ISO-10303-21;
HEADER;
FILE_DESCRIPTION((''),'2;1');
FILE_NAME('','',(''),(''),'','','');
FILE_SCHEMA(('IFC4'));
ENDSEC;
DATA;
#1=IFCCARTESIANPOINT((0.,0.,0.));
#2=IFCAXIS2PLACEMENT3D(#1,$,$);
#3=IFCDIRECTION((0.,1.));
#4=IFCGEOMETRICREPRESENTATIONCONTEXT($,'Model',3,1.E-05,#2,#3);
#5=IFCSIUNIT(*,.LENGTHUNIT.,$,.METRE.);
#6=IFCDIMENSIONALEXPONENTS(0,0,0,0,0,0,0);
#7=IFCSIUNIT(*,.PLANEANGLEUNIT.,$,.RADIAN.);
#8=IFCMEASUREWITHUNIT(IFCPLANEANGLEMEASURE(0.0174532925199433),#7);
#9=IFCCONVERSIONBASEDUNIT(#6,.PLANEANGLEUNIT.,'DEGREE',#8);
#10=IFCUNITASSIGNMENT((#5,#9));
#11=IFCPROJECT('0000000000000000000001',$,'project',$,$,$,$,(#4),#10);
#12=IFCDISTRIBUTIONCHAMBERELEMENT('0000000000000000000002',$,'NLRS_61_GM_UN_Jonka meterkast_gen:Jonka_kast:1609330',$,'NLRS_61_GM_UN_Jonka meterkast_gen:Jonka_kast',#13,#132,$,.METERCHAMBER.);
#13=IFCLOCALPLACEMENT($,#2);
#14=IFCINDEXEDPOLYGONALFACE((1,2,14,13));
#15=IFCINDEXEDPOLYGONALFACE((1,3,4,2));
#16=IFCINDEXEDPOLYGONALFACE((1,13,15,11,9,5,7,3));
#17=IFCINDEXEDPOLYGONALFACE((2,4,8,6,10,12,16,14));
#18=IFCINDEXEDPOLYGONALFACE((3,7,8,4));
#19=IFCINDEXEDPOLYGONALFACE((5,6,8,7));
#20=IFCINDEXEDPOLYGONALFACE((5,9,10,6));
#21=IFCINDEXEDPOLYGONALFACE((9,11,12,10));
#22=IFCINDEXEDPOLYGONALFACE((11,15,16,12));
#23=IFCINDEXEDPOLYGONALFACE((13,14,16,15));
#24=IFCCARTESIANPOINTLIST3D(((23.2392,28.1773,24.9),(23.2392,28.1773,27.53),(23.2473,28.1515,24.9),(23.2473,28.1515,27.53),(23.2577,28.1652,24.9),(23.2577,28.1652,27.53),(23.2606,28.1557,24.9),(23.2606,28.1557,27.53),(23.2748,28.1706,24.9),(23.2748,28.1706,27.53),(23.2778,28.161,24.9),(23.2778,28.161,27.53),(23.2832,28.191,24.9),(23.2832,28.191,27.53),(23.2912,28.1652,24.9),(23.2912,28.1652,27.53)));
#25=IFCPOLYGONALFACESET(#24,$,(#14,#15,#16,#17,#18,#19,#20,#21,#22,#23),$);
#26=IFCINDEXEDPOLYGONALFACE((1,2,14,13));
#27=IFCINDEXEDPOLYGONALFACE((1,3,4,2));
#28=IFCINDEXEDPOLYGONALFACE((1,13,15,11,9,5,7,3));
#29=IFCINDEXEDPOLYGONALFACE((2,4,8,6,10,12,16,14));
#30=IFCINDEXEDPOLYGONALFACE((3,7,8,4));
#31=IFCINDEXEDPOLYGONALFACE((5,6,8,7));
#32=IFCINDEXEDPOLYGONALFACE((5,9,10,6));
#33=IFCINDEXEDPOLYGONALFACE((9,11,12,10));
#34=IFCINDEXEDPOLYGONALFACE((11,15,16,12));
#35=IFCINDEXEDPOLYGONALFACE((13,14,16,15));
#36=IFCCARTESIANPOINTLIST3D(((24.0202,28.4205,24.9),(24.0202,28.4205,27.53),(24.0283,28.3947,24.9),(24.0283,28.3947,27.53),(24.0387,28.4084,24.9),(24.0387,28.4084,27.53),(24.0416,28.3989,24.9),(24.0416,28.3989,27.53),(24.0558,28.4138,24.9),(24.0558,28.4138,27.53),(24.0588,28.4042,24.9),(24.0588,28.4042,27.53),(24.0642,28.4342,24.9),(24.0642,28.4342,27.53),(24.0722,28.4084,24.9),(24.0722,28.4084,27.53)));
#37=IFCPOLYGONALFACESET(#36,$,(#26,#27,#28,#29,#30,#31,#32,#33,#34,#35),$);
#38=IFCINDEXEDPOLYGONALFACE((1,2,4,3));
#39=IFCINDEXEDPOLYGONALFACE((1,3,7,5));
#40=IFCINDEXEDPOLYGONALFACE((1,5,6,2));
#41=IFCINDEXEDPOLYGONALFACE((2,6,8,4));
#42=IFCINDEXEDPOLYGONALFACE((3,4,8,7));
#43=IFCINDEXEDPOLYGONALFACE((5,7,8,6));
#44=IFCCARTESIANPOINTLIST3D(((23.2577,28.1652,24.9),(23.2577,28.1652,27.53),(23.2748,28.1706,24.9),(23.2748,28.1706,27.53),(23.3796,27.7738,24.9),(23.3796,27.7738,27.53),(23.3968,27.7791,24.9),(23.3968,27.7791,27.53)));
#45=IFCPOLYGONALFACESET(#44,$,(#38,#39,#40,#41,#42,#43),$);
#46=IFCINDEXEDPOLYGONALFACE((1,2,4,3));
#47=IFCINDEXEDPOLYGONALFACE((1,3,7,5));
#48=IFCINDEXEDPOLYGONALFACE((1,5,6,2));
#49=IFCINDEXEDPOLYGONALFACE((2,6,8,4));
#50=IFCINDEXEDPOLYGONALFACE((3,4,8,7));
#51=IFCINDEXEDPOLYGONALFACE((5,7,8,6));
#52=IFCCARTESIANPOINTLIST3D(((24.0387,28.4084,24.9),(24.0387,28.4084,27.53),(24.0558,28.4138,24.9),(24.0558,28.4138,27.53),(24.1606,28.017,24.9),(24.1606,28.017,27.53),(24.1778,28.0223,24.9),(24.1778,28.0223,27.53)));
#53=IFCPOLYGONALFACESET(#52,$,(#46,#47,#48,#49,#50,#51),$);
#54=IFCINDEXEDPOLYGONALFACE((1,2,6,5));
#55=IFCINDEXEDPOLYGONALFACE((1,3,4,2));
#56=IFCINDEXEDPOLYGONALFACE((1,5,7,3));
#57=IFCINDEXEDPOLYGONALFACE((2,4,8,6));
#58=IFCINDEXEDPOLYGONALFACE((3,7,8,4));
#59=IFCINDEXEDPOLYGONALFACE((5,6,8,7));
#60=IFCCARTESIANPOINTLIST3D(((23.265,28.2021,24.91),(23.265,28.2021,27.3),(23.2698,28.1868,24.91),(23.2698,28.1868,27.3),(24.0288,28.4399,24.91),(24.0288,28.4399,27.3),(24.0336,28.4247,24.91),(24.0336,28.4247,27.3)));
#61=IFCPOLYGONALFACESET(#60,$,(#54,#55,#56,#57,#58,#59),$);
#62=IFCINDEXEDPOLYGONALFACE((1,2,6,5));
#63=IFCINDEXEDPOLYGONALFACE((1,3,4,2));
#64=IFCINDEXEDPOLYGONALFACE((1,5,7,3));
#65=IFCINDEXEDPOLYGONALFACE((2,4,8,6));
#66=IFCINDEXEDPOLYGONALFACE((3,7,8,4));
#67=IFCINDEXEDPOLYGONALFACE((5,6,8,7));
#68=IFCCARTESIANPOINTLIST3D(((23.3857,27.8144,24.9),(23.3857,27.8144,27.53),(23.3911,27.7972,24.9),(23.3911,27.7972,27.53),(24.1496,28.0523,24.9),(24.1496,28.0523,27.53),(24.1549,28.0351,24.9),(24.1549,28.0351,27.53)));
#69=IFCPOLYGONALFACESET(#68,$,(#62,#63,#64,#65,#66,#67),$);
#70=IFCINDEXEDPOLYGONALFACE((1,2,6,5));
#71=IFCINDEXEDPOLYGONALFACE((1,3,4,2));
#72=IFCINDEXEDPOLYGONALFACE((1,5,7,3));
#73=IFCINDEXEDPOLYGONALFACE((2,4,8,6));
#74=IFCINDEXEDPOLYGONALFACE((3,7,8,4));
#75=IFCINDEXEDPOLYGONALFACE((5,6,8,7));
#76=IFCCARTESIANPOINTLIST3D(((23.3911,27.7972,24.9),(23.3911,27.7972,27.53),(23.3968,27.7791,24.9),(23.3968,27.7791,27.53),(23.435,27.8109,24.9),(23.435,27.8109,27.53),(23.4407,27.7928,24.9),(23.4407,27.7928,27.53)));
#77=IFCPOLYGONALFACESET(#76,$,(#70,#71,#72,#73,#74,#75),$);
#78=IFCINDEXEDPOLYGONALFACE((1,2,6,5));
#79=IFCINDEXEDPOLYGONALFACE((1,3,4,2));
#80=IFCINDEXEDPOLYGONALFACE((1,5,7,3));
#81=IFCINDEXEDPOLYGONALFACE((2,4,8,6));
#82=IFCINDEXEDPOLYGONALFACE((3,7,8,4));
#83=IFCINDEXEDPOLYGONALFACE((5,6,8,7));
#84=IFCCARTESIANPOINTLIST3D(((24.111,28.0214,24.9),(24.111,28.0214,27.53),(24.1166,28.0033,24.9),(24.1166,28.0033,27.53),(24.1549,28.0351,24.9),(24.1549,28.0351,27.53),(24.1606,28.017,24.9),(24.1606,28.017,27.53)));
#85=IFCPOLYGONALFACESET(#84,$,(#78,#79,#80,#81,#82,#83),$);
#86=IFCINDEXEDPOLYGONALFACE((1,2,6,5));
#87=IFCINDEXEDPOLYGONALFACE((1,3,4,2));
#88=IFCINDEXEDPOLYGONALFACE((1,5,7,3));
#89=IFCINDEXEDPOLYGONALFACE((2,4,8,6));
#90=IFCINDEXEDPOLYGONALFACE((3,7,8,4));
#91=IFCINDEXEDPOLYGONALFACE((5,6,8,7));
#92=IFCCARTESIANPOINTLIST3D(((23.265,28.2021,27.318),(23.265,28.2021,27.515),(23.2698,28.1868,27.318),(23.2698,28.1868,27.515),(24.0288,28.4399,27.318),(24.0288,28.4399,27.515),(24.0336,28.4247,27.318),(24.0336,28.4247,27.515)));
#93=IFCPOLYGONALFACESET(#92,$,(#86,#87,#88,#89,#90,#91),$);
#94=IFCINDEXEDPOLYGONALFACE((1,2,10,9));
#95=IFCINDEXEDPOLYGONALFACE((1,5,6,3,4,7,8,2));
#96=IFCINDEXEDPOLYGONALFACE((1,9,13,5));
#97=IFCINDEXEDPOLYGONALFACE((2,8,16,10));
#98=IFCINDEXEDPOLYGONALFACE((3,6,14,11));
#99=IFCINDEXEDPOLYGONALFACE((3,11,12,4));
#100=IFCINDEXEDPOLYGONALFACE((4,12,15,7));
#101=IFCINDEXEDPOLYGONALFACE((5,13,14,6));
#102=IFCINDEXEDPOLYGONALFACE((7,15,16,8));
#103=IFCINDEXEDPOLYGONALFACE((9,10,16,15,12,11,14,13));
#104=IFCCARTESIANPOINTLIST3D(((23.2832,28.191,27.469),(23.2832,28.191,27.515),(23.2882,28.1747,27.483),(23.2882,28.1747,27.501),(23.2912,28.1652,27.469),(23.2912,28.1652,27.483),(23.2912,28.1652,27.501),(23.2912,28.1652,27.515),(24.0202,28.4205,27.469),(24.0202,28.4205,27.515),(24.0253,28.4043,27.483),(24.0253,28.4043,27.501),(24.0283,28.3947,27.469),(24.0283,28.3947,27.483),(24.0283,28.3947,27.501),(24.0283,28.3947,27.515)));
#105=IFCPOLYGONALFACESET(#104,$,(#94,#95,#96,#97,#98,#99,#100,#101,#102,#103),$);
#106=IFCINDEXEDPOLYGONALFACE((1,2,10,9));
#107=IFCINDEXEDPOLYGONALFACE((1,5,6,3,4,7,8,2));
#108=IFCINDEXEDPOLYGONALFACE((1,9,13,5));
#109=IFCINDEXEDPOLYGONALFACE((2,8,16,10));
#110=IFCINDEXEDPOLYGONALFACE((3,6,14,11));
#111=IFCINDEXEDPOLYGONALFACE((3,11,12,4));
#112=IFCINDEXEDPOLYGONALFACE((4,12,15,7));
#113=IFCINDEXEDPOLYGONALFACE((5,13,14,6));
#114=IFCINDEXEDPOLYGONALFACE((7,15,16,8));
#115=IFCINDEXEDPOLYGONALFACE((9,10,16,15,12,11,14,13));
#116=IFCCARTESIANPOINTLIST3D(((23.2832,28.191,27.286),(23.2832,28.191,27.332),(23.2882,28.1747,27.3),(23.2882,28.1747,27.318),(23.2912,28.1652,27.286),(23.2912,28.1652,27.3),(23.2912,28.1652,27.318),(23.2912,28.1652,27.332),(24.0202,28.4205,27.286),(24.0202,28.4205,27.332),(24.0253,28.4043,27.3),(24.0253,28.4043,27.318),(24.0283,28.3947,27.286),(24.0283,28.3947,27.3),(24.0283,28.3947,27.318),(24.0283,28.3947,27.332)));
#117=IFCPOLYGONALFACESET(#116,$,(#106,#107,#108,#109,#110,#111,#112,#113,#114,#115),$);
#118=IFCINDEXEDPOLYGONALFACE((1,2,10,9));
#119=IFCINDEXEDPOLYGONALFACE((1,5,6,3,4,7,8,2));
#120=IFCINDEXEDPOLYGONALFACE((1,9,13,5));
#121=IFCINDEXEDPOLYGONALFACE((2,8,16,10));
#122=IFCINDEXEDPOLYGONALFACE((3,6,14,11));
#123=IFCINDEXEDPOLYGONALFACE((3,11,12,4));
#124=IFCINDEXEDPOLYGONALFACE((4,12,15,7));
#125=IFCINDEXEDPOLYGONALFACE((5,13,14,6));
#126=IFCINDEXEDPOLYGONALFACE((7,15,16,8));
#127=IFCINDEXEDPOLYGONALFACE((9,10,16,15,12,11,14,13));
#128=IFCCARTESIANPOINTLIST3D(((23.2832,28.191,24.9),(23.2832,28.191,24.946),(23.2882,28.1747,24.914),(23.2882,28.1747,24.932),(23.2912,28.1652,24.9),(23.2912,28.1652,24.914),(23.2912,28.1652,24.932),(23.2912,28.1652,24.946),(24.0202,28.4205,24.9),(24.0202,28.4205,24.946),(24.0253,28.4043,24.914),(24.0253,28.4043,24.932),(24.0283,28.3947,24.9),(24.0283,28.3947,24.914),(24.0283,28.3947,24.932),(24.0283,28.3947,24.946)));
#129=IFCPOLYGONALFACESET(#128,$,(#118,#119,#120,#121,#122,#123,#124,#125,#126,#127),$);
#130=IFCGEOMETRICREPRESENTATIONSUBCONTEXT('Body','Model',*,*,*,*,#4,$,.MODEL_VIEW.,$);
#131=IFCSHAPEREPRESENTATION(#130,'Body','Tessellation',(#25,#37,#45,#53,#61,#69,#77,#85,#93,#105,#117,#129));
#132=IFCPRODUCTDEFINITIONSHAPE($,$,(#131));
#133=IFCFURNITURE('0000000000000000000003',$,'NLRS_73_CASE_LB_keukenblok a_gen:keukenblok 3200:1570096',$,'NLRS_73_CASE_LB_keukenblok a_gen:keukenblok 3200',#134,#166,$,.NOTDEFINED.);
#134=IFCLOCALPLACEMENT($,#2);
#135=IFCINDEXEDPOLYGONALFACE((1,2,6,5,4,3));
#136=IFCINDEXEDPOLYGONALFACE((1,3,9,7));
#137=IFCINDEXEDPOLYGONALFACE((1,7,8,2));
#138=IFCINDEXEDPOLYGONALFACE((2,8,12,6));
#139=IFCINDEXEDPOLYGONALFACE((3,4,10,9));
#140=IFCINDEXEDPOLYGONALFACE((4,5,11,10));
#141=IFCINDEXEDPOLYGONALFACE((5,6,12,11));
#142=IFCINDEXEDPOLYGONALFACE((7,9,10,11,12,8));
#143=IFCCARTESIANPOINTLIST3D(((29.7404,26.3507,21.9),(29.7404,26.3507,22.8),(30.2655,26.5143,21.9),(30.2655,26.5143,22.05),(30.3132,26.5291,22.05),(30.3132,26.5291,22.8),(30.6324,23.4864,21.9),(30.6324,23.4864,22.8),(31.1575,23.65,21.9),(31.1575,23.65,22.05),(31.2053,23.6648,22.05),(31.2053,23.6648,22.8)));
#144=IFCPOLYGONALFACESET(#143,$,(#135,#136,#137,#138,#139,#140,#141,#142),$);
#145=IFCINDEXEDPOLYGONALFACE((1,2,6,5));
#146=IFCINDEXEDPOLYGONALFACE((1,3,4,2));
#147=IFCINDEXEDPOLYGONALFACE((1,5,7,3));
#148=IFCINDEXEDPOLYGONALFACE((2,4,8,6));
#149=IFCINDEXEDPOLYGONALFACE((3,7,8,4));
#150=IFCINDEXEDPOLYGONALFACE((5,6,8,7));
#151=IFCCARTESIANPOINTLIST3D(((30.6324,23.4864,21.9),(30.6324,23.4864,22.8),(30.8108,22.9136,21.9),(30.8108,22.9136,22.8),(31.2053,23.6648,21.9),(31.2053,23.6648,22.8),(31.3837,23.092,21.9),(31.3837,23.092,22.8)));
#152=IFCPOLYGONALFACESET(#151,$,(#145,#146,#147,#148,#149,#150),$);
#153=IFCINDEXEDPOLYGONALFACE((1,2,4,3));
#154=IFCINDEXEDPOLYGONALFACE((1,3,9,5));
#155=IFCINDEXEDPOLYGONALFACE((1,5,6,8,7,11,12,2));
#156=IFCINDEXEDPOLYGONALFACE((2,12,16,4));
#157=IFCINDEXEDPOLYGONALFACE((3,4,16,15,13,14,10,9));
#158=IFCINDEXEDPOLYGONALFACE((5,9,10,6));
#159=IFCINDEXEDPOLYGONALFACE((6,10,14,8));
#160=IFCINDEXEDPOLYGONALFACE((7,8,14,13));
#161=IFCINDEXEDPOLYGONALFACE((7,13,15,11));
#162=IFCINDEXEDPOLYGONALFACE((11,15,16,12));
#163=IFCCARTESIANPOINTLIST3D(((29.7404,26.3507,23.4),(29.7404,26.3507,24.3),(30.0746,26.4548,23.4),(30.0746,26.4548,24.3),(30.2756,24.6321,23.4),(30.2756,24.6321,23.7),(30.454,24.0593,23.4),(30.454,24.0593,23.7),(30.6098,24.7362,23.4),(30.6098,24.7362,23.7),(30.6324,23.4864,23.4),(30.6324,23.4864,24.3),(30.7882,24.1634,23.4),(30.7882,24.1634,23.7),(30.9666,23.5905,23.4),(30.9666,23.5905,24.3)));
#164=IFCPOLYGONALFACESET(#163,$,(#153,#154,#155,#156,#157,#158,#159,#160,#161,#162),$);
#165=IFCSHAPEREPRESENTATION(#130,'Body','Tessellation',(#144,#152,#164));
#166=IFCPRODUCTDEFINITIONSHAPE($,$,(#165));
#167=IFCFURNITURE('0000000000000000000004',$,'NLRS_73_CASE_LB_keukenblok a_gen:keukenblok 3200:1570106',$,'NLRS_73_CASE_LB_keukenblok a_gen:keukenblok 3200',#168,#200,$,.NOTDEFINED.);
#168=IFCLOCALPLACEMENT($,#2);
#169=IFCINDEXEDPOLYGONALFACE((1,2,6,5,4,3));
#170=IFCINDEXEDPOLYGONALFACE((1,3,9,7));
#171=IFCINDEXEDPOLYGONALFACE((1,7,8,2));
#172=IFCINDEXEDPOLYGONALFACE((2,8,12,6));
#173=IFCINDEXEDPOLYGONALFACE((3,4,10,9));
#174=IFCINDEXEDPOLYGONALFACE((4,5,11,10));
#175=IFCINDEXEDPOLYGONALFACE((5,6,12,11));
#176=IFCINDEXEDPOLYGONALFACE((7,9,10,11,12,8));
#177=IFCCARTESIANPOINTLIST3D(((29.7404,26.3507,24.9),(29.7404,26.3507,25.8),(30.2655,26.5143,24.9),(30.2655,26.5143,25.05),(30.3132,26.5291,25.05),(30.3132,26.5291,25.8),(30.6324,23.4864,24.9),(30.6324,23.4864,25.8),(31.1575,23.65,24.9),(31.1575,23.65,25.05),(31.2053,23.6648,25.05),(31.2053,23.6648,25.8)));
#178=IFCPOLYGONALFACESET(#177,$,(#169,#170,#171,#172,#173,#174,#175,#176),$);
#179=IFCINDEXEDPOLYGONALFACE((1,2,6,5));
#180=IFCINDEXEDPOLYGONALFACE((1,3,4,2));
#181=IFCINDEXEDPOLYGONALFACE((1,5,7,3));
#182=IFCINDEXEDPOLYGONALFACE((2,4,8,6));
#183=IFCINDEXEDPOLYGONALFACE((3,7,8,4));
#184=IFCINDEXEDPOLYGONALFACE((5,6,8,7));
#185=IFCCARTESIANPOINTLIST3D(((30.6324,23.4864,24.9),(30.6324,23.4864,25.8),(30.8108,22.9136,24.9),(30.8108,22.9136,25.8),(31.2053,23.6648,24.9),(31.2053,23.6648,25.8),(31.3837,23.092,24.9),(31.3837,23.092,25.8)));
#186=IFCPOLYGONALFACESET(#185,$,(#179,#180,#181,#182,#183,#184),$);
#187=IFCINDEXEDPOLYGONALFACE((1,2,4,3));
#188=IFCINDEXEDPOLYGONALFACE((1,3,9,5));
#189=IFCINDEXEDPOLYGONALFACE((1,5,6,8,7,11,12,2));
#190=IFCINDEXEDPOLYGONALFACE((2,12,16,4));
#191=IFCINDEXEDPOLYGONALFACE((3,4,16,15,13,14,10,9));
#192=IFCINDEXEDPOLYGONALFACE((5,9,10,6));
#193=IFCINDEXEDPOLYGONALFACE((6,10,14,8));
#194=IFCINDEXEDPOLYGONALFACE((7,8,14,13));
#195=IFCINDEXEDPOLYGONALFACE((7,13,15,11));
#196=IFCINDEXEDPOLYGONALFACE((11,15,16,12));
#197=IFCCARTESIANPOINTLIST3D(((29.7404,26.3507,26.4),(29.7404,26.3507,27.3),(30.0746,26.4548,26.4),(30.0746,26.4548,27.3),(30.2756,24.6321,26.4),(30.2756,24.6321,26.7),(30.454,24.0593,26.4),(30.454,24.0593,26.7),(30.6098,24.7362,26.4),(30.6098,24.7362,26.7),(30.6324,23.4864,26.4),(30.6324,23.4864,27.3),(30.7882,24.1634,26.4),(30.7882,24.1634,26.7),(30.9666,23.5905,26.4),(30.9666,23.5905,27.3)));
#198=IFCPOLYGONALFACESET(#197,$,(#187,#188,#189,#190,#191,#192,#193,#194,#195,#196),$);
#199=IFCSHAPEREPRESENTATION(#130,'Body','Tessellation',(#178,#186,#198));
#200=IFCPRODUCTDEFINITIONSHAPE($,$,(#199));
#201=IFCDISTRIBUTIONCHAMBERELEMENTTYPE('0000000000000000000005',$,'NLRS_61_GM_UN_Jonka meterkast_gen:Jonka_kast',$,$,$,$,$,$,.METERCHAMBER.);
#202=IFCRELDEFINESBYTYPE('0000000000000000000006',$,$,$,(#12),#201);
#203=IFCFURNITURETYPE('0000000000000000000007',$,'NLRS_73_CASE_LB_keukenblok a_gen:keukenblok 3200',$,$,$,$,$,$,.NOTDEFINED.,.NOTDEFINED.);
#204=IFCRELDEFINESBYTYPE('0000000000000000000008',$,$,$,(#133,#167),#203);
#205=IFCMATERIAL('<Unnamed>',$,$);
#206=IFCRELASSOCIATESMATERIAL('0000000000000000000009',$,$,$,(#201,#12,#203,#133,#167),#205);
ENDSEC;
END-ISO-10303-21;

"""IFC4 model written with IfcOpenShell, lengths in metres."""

from ifc_helpers import new_model, entity, si_unit, converted_unit, direction, frame, origin, place, context, subcontext, project, indexed_curve, outline, extrude, source, transform, mapped, material, type_object, type_shapes, element, save


model = new_model("IFC4")

# Units and contexts
model_context = context("Model", 3, precision=1e-05, world=origin(), true_north=direction((0.0, 1.0)))
body_context = subcontext(model_context, "Body", "Model", "MODEL_VIEW")
ifc_project = project(units=[si_unit("LENGTHUNIT", "METRE"), converted_unit("PLANEANGLEUNIT", "DEGREE", entity("IfcPlaneAngleMeasure", 0.0174532925199433), si_unit("PLANEANGLEUNIT", "RADIAN"), dimensions=[0, 0, 0, 0, 0, 0, 0])], contexts=[model_context])

# Shared definitions
ifc_material = material(Name="<Unnamed>")
distribution_chamber_element_type = type_object("IfcDistributionChamberElementType", Name="NLRS_61_GM_UN_Jonka meterkast_gen:Jonka_kast", PredefinedType="METERCHAMBER", material=ifc_material)
placement_1 = place(None, frame((13.1348, 11.9886, 0.0), z_axis=(0.0, 0.0, 1.0), x_axis=(0.954771, 0.297342, 0.0)))
placement_2 = place(placement_1, origin())
placement_3 = place(placement_2, frame((0.0, 0.0, 21.9)))
placement_4 = place(placement_2, frame((0.0, 0.0, 24.9)))

# Distribution chamber element
shared_shape_1 = source(origin(), body_context, "Body", "SweptSolid", [
    extrude(outline(indexed_curve([(-0.023, -0.0093), (-0.009, -0.0093), (-0.009, 0.0007), (0.009, 0.0007), (0.009, -0.0093), (0.023, -0.0093), (0.023, 0.0178), (-0.023, 0.0178), (-0.023, -0.0093)], self_intersect=False)), frame((-0.409, 0.4092, 0.0)), (0.0, 0.0, 1.0), 2.63),
    extrude(outline(indexed_curve([(-0.023, -0.0093), (-0.009, -0.0093), (-0.009, 0.0007), (0.009, 0.0007), (0.009, -0.0093), (0.023, -0.0093), (0.023, 0.0178), (-0.023, 0.0178), (-0.023, -0.0093)], self_intersect=False)), frame((0.409, 0.4092, 0.0)), (0.0, 0.0, 1.0), 2.63),
    extrude(outline(indexed_curve([(-0.009, -0.205), (0.009, -0.205), (0.009, 0.205), (-0.009, 0.205), (-0.009, -0.205)], self_intersect=False)), frame((-0.409, 0.205, 0.0)), (0.0, 0.0, 1.0), 2.63),
    extrude(outline(indexed_curve([(-0.009, -0.205), (0.009, -0.205), (0.009, 0.205), (-0.009, 0.205), (-0.009, -0.205)], self_intersect=False)), frame((0.409, 0.205, 0.0)), (0.0, 0.0, 1.0), 2.63),
    extrude(outline(indexed_curve([(-0.008, -0.4), (0.008, -0.4), (0.008, 0.4), (-0.008, 0.4), (-0.008, -0.4)], self_intersect=False)), frame((0.0, 0.435, 0.01), z_axis=(0.0, 0.0, 1.0), x_axis=(0.0, 1.0, 0.0)), (0.0, 0.0, 1.0), 2.39),
    extrude(outline(indexed_curve([(-0.009, -0.4), (0.009, -0.4), (0.009, 0.4), (-0.009, 0.4), (-0.009, -0.4)], self_intersect=False)), frame((0.0, 0.028, 0.0), z_axis=(0.0, 0.0, 1.0), x_axis=(0.0, 1.0, 0.0)), (0.0, 0.0, 1.0), 2.63),
    extrude(outline(indexed_curve([(-0.0095, -0.023), (0.0095, -0.023), (0.0095, 0.023), (-0.0095, 0.023), (-0.0095, -0.023)], self_intersect=False)), frame((-0.377, 0.0095, 0.0), z_axis=(0.0, 0.0, 1.0), x_axis=(0.0, 1.0, 0.0)), (0.0, 0.0, 1.0), 2.63),
    extrude(outline(indexed_curve([(-0.0095, -0.023), (0.0095, -0.023), (0.0095, 0.023), (-0.0095, 0.023), (-0.0095, -0.023)], self_intersect=False)), frame((0.377, 0.0095, 0.0), z_axis=(0.0, 0.0, 1.0), x_axis=(0.0, 1.0, 0.0)), (0.0, 0.0, 1.0), 2.63),
    extrude(outline(indexed_curve([(-0.008, -0.4), (0.008, -0.4), (0.008, 0.4), (-0.008, 0.4), (-0.008, -0.4)], self_intersect=False)), frame((0.0, 0.435, 2.418), z_axis=(0.0, 0.0, 1.0), x_axis=(0.0, 1.0, 0.0)), (0.0, 0.0, 1.0), 0.197),
    extrude(outline(indexed_curve([(-0.0178, -0.023), (0.0093, -0.023), (0.0093, -0.009), (-0.0007, -0.009), (-0.0007, 0.009), (0.0093, 0.009), (0.0093, 0.023), (-0.0178, 0.023), (-0.0178, -0.023)], self_intersect=False)), frame((-0.386, 0.4092, 2.592), z_axis=(1.0, 0.0, 0.0), x_axis=(0.0, -1.0, 0.0)), (0.0, 0.0, 1.0), 0.772),
    extrude(outline(indexed_curve([(-0.0178, -0.023), (0.0093, -0.023), (0.0093, -0.009), (-0.0007, -0.009), (-0.0007, 0.009), (0.0093, 0.009), (0.0093, 0.023), (-0.0178, 0.023), (-0.0178, -0.023)], self_intersect=False)), frame((-0.386, 0.4092, 2.409), z_axis=(1.0, 0.0, 0.0), x_axis=(0.0, -1.0, 0.0)), (0.0, 0.0, 1.0), 0.772),
    extrude(outline(indexed_curve([(-0.0178, -0.023), (0.0093, -0.023), (0.0093, -0.009), (-0.0007, -0.009), (-0.0007, 0.009), (0.0093, 0.009), (0.0093, 0.023), (-0.0178, 0.023), (-0.0178, -0.023)], self_intersect=False)), frame((-0.386, 0.4092, 0.023), z_axis=(1.0, 0.0, 0.0), x_axis=(0.0, -1.0, 0.0)), (0.0, 0.0, 1.0), 0.772),
])
placement_5 = place(placement_4, origin())
distribution_chamber_element_1_placement = place(placement_5, frame((14.893, 12.025, 0.0)))
element("IfcDistributionChamberElement", 1, at=distribution_chamber_element_1_placement, type_object=distribution_chamber_element_type, material=ifc_material, Name="NLRS_61_GM_UN_Jonka meterkast_gen:Jonka_kast:1609330", ObjectType="NLRS_61_GM_UN_Jonka meterkast_gen:Jonka_kast", PredefinedType="METERCHAMBER", context=body_context, shape_type="MappedRepresentation", body=[
    mapped(shared_shape_1, transform((0.0, 0.0, 0.0), scale=1.0)),
])

# Furniture
furniture_type = type_object("IfcFurnitureType", Name="NLRS_73_CASE_LB_keukenblok a_gen:keukenblok 3200", AssemblyPlace="NOTDEFINED", PredefinedType="NOTDEFINED", material=ifc_material)
shared_shape_2 = source(origin(), body_context, "Body", "SweptSolid", [
    extrude(outline(indexed_curve([(-0.35, 0.1667), (-0.35, -0.3833), (0.55, -0.3833), (0.55, 0.2167), (-0.2, 0.2167), (-0.2, 0.1667), (-0.35, 0.1667)], self_intersect=False)), frame((0.0, 0.3833, 0.35), z_axis=(-1.0, 0.0, 0.0), x_axis=(0.0, 0.0, 1.0)), (0.0, 0.0, -1.0), 3.0),
    extrude(outline(indexed_curve([(-0.3, -0.3), (0.3, -0.3), (0.3, 0.3), (-0.3, 0.3), (-0.3, -0.3)], self_intersect=False)), frame((3.3, 0.3, 0.0), z_axis=(0.0, 0.0, 1.0), x_axis=(0.0, 1.0, 0.0)), (0.0, 0.0, 1.0), 0.9),
    extrude(outline(indexed_curve([(-1.2, -0.3), (-0.6, -0.3), (-0.6, 0.0), (0.0, 0.0), (0.0, -0.3), (1.8, -0.3), (1.8, 0.6), (-1.2, 0.6), (-1.2, -0.3)], self_intersect=False)), frame((1.8, 0.0, 1.8), z_axis=(0.0, 1.0, 0.0), x_axis=(-1.0, 0.0, 0.0)), (0.0, 0.0, 1.0), 0.35),
])
type_shapes(furniture_type, [shared_shape_2])
placement_6 = place(placement_3, origin())
furniture_1_placement = place(placement_6, frame((20.125, 8.775, 0.0), z_axis=(0.0, 0.0, 1.0), x_axis=(0.0, -1.0, 0.0)))
element("IfcFurniture", 2, at=furniture_1_placement, type_object=furniture_type, material=ifc_material, Name="NLRS_73_CASE_LB_keukenblok a_gen:keukenblok 3200:1570096", ObjectType="NLRS_73_CASE_LB_keukenblok a_gen:keukenblok 3200", PredefinedType="NOTDEFINED", context=body_context, shape_type="MappedRepresentation", body=[
    mapped(shared_shape_2, transform((0.0, 0.0, 0.0), scale=1.0)),
])
placement_7 = place(placement_4, origin())
furniture_2_placement = place(placement_7, frame((20.125, 8.775, 0.0), z_axis=(0.0, 0.0, 1.0), x_axis=(0.0, -1.0, 0.0)))
element("IfcFurniture", 3, at=furniture_2_placement, type_object=furniture_type, material=ifc_material, Name="NLRS_73_CASE_LB_keukenblok a_gen:keukenblok 3200:1570106", ObjectType="NLRS_73_CASE_LB_keukenblok a_gen:keukenblok 3200", PredefinedType="NOTDEFINED", context=body_context, shape_type="MappedRepresentation", body=[
    mapped(shared_shape_2, transform((0.0, 0.0, 0.0), scale=1.0)),
])

save(model, "model.ifc")
